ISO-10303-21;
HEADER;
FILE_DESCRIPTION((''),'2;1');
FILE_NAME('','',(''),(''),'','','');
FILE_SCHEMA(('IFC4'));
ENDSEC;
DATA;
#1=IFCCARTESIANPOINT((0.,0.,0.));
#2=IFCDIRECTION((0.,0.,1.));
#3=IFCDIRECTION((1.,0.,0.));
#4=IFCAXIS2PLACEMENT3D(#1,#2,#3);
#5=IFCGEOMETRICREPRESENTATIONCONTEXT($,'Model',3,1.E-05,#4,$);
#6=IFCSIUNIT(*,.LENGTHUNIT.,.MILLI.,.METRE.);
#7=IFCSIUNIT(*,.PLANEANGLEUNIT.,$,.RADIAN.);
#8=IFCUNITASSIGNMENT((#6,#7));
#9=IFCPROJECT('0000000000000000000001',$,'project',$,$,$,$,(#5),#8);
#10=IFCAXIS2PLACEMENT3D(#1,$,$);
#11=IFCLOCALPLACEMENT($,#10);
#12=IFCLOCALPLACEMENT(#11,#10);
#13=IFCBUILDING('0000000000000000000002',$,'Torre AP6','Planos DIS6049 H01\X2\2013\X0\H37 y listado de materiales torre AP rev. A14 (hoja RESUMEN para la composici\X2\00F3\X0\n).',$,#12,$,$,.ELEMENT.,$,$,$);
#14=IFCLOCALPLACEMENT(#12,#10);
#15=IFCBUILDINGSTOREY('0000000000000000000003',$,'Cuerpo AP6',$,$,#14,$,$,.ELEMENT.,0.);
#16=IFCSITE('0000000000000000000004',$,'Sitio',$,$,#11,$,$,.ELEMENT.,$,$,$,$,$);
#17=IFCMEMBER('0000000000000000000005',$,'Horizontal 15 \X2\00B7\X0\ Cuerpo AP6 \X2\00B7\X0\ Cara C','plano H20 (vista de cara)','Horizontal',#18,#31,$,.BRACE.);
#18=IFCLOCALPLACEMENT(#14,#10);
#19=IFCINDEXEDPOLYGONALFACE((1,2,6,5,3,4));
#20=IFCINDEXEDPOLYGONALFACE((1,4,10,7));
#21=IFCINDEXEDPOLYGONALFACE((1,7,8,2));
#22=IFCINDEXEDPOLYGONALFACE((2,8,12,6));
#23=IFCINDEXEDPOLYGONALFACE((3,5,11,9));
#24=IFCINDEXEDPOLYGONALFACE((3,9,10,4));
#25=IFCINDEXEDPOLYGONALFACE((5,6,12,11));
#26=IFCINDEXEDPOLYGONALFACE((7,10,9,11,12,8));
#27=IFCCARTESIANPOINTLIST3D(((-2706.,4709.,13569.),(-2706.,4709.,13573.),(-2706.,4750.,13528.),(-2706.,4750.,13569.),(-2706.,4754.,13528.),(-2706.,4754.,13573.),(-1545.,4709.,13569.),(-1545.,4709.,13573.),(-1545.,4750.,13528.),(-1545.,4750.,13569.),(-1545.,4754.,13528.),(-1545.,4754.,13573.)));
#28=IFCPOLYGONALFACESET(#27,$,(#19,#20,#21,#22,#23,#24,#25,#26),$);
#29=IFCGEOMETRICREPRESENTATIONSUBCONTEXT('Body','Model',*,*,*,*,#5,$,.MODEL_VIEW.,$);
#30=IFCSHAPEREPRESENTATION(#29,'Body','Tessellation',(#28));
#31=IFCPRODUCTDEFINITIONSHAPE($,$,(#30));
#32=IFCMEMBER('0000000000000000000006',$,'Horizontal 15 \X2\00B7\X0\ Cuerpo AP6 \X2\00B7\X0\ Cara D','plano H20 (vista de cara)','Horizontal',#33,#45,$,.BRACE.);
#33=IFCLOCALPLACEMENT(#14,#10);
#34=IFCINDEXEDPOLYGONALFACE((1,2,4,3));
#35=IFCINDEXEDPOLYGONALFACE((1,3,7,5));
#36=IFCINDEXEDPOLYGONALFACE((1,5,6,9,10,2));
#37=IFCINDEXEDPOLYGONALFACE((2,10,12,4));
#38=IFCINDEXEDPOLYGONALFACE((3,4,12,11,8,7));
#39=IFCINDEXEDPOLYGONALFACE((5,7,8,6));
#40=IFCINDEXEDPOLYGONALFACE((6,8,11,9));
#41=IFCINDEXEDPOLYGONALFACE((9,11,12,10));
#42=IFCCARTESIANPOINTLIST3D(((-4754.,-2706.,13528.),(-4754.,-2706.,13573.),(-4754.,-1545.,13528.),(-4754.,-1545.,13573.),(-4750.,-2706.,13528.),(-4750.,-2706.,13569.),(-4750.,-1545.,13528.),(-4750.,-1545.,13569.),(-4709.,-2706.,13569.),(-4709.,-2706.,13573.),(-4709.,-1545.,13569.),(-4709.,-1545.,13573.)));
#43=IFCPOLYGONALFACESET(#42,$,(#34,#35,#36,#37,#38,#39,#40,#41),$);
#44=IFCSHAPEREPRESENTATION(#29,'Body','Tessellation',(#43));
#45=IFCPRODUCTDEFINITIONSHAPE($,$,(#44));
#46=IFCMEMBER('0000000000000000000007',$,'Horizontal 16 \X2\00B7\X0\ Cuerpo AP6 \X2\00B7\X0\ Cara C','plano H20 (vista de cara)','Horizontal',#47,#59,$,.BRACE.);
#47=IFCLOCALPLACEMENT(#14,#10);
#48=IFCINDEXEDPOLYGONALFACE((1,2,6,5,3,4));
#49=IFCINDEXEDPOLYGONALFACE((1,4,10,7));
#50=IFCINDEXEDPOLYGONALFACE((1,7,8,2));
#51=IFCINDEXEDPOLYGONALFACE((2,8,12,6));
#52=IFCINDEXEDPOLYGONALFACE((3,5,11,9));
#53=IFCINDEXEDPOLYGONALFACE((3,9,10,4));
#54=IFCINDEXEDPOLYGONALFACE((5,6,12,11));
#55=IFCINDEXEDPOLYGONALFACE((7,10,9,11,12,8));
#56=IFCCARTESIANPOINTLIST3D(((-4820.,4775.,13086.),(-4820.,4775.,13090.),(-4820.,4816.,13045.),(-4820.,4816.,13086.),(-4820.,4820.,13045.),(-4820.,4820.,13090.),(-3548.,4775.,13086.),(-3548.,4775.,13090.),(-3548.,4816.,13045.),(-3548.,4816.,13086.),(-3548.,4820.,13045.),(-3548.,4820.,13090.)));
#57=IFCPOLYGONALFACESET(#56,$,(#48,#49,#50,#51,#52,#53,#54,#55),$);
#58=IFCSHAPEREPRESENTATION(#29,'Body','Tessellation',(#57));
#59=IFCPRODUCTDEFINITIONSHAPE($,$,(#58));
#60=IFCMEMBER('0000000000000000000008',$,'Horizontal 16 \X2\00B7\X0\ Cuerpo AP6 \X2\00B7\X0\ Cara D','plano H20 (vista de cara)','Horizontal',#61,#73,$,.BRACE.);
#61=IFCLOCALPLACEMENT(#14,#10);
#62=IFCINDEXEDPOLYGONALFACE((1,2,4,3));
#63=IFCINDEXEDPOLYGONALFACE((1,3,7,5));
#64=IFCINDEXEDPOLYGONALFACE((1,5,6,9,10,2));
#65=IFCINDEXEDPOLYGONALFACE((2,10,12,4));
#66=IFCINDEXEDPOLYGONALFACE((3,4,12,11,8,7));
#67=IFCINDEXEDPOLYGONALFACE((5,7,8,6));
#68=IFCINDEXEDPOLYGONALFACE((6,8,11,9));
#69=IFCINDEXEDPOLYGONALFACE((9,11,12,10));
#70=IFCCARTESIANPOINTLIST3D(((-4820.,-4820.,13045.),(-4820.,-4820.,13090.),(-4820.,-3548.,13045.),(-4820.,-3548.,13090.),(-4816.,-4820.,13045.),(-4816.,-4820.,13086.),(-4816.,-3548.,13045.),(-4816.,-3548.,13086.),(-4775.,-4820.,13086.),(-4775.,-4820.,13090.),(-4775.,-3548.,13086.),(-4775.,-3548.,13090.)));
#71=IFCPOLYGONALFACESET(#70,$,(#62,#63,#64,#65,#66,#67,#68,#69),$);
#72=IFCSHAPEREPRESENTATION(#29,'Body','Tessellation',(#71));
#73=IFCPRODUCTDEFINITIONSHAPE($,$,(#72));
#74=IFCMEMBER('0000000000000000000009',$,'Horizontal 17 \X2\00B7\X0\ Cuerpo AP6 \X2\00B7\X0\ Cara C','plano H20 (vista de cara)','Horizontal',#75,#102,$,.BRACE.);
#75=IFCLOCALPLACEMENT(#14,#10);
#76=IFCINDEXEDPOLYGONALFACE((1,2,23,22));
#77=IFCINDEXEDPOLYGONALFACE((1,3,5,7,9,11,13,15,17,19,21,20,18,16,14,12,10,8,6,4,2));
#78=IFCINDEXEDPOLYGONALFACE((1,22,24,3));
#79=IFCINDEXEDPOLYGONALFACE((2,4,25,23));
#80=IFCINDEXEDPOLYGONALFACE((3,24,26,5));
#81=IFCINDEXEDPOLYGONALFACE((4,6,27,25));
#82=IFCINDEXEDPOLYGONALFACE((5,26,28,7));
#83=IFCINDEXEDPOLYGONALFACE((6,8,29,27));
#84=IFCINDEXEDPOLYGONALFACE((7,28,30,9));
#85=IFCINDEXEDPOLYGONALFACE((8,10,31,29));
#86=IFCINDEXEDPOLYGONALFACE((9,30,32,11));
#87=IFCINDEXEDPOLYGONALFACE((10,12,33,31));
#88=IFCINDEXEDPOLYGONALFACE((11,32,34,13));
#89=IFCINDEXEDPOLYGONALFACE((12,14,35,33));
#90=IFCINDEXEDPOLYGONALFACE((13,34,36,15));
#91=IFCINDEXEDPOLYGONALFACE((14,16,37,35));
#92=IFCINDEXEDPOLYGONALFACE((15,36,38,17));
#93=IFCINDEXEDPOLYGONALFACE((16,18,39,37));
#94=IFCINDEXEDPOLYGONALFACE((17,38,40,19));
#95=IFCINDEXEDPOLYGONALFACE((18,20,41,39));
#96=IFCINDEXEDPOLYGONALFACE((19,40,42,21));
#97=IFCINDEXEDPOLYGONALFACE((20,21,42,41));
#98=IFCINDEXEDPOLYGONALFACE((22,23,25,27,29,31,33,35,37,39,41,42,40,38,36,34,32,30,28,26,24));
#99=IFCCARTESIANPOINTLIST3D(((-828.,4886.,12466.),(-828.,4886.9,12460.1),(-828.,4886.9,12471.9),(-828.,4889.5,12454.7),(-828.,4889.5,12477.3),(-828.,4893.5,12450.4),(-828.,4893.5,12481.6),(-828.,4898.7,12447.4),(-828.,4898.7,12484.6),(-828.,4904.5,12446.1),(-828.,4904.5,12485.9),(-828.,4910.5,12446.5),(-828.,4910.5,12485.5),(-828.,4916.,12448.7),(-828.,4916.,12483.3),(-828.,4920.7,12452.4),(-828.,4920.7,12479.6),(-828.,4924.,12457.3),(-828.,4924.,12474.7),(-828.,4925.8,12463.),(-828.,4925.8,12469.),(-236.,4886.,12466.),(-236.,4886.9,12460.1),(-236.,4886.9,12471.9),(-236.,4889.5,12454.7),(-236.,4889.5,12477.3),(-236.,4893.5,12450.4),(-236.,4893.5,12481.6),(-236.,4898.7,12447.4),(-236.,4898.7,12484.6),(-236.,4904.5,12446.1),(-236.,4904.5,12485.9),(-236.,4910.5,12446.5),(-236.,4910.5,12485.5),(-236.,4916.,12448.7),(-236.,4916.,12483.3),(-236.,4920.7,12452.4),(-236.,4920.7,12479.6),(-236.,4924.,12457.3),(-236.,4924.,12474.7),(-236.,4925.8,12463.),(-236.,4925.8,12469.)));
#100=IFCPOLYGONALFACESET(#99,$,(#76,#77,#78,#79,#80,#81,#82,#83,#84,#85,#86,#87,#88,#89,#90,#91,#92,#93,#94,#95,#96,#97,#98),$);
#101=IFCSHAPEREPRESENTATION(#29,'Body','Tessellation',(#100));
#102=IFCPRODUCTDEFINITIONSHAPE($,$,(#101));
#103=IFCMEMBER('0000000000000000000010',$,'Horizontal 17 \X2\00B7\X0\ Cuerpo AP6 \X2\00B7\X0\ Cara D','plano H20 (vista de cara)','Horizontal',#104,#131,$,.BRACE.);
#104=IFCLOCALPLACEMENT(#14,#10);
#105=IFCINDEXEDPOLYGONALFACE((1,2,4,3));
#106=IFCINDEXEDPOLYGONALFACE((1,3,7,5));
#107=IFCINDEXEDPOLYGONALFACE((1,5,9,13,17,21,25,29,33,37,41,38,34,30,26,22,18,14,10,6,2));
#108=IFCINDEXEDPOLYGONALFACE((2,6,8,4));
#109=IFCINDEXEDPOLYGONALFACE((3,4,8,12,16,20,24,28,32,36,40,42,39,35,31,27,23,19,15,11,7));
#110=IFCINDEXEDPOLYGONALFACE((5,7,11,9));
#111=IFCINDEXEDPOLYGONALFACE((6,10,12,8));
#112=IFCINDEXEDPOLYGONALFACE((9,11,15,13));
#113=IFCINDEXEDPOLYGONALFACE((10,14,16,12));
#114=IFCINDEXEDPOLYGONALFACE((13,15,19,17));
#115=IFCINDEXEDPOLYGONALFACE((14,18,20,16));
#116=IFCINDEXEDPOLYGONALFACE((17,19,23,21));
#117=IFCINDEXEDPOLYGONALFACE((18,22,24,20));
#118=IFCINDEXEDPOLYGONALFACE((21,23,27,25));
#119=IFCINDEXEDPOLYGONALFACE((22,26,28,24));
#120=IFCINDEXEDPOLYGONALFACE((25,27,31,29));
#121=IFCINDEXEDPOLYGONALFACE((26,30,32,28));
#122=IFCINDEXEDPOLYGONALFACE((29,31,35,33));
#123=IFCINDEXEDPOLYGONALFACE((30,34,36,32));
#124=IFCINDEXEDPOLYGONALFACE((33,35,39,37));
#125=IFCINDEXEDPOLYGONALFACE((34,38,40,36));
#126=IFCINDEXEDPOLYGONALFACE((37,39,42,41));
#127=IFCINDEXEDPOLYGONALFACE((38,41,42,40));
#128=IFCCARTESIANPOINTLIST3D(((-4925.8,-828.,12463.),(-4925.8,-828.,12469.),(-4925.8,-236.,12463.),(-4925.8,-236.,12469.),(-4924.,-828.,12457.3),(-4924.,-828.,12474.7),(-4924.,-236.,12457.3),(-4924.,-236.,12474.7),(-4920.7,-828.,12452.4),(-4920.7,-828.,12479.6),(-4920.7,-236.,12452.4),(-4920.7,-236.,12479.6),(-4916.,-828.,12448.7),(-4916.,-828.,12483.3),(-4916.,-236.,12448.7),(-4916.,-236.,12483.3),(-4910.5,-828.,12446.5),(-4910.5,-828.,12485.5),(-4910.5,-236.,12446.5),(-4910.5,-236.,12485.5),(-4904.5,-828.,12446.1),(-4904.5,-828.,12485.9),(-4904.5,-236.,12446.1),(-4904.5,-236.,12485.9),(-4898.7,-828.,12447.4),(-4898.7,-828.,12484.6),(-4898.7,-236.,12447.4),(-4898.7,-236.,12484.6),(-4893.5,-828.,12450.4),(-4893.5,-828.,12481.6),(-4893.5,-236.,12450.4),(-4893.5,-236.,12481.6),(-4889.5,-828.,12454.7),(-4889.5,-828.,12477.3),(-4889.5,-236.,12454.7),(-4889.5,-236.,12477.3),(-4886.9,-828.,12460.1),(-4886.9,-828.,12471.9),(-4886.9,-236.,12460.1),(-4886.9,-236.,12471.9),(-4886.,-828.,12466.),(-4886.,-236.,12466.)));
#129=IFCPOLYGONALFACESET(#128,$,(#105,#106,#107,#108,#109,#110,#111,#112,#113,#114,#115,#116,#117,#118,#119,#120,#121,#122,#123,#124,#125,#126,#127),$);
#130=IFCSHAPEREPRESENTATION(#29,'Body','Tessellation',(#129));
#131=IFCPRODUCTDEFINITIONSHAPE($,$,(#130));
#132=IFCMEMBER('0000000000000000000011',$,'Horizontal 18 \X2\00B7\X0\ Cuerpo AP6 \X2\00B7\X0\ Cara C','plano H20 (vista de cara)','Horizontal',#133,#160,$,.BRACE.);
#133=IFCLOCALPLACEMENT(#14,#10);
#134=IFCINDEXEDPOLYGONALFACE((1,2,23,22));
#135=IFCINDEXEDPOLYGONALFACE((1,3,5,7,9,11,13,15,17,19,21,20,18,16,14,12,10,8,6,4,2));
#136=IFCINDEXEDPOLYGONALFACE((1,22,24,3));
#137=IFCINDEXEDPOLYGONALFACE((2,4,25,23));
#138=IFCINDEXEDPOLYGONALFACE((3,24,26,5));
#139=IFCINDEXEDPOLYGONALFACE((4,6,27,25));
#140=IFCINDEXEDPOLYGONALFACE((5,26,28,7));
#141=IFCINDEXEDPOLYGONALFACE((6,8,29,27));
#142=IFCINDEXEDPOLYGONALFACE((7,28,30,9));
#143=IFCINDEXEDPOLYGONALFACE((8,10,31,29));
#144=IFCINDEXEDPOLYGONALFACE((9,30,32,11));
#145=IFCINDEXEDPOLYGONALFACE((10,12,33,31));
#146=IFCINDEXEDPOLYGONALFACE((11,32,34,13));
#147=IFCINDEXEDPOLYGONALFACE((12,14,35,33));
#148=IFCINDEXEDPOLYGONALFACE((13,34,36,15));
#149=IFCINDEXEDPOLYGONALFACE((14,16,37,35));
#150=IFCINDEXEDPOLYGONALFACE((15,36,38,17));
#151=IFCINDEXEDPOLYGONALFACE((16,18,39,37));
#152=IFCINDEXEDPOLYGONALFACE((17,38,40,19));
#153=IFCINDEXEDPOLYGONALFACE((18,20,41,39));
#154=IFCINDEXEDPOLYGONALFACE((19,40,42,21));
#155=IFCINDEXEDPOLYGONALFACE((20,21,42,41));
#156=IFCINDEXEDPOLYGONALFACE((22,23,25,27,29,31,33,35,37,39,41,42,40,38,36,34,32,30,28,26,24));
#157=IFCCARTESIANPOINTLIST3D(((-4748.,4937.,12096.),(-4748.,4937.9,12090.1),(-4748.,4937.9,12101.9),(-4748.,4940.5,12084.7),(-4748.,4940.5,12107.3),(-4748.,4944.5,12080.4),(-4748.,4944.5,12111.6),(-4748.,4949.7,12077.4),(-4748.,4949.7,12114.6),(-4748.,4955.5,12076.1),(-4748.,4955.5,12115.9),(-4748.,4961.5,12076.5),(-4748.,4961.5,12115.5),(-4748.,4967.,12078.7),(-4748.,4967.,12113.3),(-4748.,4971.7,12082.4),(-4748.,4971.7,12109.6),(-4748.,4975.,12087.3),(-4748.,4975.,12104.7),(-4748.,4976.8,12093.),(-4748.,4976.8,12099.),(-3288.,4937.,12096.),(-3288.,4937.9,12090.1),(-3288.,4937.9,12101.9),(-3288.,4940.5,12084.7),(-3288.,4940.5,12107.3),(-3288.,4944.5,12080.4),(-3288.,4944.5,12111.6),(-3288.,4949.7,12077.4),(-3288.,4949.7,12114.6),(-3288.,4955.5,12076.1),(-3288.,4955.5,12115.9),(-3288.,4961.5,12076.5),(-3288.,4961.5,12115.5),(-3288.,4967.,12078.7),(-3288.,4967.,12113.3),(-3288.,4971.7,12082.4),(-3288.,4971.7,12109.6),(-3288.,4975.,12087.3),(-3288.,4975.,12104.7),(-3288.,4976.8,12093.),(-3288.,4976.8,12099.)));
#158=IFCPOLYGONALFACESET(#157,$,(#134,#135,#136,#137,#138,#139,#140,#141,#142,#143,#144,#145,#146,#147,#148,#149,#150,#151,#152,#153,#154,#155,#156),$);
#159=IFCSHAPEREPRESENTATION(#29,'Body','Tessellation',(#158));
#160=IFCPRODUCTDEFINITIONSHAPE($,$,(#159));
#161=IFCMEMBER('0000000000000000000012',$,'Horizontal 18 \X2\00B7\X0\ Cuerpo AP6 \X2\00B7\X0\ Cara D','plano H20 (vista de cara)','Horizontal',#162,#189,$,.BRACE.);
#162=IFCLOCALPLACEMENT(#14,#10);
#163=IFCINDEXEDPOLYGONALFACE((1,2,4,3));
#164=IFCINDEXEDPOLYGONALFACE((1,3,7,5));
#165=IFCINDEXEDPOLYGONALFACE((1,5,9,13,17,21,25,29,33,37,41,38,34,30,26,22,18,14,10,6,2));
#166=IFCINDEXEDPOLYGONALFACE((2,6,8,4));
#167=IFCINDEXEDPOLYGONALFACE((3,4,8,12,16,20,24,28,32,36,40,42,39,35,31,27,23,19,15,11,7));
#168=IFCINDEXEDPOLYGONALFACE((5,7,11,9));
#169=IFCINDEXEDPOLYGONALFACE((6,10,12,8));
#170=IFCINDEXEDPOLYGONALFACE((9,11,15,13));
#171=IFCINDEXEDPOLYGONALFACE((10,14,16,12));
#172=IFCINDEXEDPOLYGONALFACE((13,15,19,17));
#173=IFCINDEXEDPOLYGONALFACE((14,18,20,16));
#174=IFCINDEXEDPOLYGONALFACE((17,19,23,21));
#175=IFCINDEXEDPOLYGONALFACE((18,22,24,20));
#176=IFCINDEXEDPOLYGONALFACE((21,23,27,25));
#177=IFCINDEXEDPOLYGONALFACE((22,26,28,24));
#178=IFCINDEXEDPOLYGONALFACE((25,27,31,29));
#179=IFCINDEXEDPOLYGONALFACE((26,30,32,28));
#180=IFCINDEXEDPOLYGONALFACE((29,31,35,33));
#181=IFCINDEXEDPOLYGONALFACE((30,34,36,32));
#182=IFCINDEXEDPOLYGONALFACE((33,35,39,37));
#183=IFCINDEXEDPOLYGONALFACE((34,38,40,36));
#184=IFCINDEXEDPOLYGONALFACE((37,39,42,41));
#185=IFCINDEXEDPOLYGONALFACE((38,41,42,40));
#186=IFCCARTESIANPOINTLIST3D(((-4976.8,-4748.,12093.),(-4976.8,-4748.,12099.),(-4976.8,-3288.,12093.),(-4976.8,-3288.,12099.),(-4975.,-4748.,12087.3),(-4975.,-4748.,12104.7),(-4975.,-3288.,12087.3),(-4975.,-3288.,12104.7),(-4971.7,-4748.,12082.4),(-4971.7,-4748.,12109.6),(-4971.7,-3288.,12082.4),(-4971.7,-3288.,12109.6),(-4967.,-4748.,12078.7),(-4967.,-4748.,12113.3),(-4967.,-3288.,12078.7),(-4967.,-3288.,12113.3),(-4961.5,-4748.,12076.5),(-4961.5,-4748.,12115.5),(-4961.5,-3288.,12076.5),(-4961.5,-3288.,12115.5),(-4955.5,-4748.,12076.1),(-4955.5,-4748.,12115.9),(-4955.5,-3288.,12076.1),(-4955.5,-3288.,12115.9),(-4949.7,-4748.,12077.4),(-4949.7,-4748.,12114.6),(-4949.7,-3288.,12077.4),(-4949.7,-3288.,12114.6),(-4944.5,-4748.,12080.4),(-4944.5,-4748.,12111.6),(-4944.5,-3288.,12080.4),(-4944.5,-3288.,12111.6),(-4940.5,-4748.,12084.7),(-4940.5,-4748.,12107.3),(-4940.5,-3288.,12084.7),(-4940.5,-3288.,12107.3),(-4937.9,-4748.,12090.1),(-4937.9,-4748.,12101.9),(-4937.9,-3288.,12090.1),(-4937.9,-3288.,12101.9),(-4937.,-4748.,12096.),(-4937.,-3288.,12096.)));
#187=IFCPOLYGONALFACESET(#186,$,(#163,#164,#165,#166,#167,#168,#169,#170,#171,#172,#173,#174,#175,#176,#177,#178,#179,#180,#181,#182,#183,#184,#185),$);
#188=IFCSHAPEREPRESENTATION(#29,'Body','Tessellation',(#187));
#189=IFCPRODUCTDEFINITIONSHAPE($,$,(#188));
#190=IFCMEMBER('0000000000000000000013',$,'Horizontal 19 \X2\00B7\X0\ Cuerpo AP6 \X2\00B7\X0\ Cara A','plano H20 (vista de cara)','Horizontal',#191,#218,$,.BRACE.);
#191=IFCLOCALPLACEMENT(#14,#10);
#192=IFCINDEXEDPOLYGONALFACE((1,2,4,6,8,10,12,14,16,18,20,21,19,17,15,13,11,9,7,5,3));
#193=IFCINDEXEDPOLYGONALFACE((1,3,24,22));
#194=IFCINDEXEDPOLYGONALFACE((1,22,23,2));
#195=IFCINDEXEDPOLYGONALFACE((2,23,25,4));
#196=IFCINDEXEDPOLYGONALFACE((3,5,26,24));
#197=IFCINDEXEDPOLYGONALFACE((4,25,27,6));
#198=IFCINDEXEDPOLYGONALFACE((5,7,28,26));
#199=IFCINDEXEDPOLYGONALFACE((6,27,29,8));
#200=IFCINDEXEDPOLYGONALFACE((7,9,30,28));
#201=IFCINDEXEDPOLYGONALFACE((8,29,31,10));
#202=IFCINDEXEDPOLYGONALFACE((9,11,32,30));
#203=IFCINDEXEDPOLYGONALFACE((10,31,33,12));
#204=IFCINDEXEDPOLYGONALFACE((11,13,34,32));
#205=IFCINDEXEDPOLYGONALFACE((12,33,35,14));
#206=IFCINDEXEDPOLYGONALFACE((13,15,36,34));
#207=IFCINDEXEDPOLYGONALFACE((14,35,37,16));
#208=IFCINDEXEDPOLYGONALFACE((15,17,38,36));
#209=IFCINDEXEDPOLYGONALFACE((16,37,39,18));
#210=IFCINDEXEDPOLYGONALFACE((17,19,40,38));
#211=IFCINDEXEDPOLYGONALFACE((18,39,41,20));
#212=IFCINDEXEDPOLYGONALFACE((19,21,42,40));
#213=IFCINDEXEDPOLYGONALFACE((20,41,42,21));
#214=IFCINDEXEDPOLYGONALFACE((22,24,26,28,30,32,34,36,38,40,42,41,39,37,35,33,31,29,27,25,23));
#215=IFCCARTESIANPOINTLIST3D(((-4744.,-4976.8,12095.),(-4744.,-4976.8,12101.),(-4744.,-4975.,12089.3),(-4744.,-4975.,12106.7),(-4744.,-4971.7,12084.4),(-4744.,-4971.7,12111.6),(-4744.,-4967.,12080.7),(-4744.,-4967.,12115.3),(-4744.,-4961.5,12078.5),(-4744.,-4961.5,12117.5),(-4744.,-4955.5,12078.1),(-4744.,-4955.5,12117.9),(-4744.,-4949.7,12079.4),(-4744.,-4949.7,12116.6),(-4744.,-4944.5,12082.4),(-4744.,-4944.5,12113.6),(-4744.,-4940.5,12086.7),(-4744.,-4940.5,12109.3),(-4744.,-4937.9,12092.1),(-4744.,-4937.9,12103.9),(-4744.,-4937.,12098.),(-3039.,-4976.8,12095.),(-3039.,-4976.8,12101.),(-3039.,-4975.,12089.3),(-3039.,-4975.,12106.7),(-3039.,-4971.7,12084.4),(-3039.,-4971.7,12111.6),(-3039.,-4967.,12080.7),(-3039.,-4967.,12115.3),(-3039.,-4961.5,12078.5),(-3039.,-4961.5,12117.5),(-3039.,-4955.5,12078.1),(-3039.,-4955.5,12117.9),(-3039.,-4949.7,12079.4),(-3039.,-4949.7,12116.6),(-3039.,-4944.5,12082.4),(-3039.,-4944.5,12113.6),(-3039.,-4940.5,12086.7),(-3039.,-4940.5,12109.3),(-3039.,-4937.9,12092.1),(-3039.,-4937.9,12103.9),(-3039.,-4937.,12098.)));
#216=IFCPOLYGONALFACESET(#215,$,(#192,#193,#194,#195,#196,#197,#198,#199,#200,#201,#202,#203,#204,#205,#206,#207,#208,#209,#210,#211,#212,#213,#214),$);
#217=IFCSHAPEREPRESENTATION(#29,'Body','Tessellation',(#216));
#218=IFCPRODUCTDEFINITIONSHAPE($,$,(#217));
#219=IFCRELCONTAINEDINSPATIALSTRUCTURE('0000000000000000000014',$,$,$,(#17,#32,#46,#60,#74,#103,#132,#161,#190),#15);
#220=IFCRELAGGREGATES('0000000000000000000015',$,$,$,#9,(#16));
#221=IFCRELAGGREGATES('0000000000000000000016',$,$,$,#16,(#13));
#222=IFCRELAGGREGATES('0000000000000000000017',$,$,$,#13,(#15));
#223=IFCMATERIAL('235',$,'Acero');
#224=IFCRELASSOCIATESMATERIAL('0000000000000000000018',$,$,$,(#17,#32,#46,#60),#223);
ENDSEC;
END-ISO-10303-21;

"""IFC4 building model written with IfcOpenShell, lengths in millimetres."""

from ifc_helpers import new_model, si_unit, frame, frame_2d, origin, origin_with_axes, place, context, subcontext, project, spatial, circle, l_section, extrude, material, element, save


model = new_model("IFC4")

# Units and contexts
model_context = context("Model", 3, precision=1e-05, world=origin_with_axes())
body_context = subcontext(model_context, "Body", "Model", "MODEL_VIEW")
ifc_project = project(units=[si_unit("LENGTHUNIT", "METRE", prefix="MILLI"), si_unit("PLANEANGLEUNIT", "RADIAN")], contexts=[model_context])

# Site, building, storey
site_placement = place(None, origin())
site = spatial("IfcSite", under=ifc_project, at=site_placement, Name="Sitio", CompositionType="ELEMENT")
building_placement = place(site_placement, origin())
building = spatial("IfcBuilding", under=site, at=building_placement, Name="Torre AP6", Description="Planos DIS6049 H01–H37 y listado de materiales torre AP rev. A14 (hoja RESUMEN para la composición).", CompositionType="ELEMENT")
storey_placement = place(building_placement, origin())
storey = spatial("IfcBuildingStorey", under=building, at=storey_placement, Name="Cuerpo AP6", CompositionType="ELEMENT", Elevation=0.0)

# Members
ifc_material_1 = material(Name="235", Category="Acero")
for number, where, z_axis, x_axis, name in (
    (1, (-2706.0, 4754.0, 13573.0), (1.0, 0.0, 0.0), (0.0, -1.0, 0.0), "Horizontal 15 · Cuerpo AP6 · Cara C"),
    (2, (-4754.0, -2706.0, 13573.0), (0.0, 1.0, 0.0), (1.0, 0.0, 0.0), "Horizontal 15 · Cuerpo AP6 · Cara D"),
):
    element("IfcMember", number, at=place(storey_placement, frame(where, z_axis=z_axis, x_axis=x_axis)), inside=storey, material=ifc_material_1, Name=name, Description="plano H20 (vista de cara)", ObjectType="Horizontal", PredefinedType="BRACE", context=body_context, shape_type="SweptSolid", body=[
        extrude(l_section(Depth=45.0, Width=45.0, Thickness=4.0, at=frame_2d((22.5, 22.5))), None, (0.0, 0.0, 1.0), 1161.0),
    ])
for number, where, z_axis, x_axis, name in (
    (3, (-4820.0, 4820.0, 13090.0), (1.0, 0.0, 0.0), (0.0, -1.0, 0.0), "Horizontal 16 · Cuerpo AP6 · Cara C"),
    (4, (-4820.0, -4820.0, 13090.0), (0.0, 1.0, 0.0), (1.0, 0.0, 0.0), "Horizontal 16 · Cuerpo AP6 · Cara D"),
):
    element("IfcMember", number, at=place(storey_placement, frame(where, z_axis=z_axis, x_axis=x_axis)), inside=storey, material=ifc_material_1, Name=name, Description="plano H20 (vista de cara)", ObjectType="Horizontal", PredefinedType="BRACE", context=body_context, shape_type="SweptSolid", body=[
        extrude(l_section(Depth=45.0, Width=45.0, Thickness=4.0, at=frame_2d((22.5, 22.5))), None, (0.0, 0.0, 1.0), 1272.0),
    ])
for number, where, z_axis, x_axis, name in (
    (5, (-828.0, 4906.0, 12466.0), (1.0, 0.0, 0.0), (0.0, -1.0, 0.0), "Horizontal 17 · Cuerpo AP6 · Cara C"),
    (6, (-4906.0, -828.0, 12466.0), (0.0, 1.0, 0.0), (1.0, 0.0, 0.0), "Horizontal 17 · Cuerpo AP6 · Cara D"),
):
    element("IfcMember", number, at=place(storey_placement, frame(where, z_axis=z_axis, x_axis=x_axis)), inside=storey, Name=name, Description="plano H20 (vista de cara)", ObjectType="Horizontal", PredefinedType="BRACE", context=body_context, shape_type="SweptSolid", body=[
        extrude(circle(Radius=20.0), None, (0.0, 0.0, 1.0), 592.0),
    ])
for number, where, z_axis, x_axis, name in (
    (7, (-4748.0, 4957.0, 12096.0), (1.0, 0.0, 0.0), (0.0, -1.0, 0.0), "Horizontal 18 · Cuerpo AP6 · Cara C"),
    (8, (-4957.0, -4748.0, 12096.0), (0.0, 1.0, 0.0), (1.0, 0.0, 0.0), "Horizontal 18 · Cuerpo AP6 · Cara D"),
):
    element("IfcMember", number, at=place(storey_placement, frame(where, z_axis=z_axis, x_axis=x_axis)), inside=storey, Name=name, Description="plano H20 (vista de cara)", ObjectType="Horizontal", PredefinedType="BRACE", context=body_context, shape_type="SweptSolid", body=[
        extrude(circle(Radius=20.0), None, (0.0, 0.0, 1.0), 1460.0),
    ])
for number, where, z_axis, x_axis, name in (
    (9, (-3039.0, -4957.0, 12098.0), (-1.0, 0.0, 0.0), (0.0, 1.0, 0.0), "Horizontal 19 · Cuerpo AP6 · Cara A"),
):
    element("IfcMember", number, at=place(storey_placement, frame(where, z_axis=z_axis, x_axis=x_axis)), inside=storey, Name=name, Description="plano H20 (vista de cara)", ObjectType="Horizontal", PredefinedType="BRACE", context=body_context, shape_type="SweptSolid", body=[
        extrude(circle(Radius=20.0), None, (0.0, 0.0, 1.0), 1705.0),
    ])

save(model, "model.ifc")
